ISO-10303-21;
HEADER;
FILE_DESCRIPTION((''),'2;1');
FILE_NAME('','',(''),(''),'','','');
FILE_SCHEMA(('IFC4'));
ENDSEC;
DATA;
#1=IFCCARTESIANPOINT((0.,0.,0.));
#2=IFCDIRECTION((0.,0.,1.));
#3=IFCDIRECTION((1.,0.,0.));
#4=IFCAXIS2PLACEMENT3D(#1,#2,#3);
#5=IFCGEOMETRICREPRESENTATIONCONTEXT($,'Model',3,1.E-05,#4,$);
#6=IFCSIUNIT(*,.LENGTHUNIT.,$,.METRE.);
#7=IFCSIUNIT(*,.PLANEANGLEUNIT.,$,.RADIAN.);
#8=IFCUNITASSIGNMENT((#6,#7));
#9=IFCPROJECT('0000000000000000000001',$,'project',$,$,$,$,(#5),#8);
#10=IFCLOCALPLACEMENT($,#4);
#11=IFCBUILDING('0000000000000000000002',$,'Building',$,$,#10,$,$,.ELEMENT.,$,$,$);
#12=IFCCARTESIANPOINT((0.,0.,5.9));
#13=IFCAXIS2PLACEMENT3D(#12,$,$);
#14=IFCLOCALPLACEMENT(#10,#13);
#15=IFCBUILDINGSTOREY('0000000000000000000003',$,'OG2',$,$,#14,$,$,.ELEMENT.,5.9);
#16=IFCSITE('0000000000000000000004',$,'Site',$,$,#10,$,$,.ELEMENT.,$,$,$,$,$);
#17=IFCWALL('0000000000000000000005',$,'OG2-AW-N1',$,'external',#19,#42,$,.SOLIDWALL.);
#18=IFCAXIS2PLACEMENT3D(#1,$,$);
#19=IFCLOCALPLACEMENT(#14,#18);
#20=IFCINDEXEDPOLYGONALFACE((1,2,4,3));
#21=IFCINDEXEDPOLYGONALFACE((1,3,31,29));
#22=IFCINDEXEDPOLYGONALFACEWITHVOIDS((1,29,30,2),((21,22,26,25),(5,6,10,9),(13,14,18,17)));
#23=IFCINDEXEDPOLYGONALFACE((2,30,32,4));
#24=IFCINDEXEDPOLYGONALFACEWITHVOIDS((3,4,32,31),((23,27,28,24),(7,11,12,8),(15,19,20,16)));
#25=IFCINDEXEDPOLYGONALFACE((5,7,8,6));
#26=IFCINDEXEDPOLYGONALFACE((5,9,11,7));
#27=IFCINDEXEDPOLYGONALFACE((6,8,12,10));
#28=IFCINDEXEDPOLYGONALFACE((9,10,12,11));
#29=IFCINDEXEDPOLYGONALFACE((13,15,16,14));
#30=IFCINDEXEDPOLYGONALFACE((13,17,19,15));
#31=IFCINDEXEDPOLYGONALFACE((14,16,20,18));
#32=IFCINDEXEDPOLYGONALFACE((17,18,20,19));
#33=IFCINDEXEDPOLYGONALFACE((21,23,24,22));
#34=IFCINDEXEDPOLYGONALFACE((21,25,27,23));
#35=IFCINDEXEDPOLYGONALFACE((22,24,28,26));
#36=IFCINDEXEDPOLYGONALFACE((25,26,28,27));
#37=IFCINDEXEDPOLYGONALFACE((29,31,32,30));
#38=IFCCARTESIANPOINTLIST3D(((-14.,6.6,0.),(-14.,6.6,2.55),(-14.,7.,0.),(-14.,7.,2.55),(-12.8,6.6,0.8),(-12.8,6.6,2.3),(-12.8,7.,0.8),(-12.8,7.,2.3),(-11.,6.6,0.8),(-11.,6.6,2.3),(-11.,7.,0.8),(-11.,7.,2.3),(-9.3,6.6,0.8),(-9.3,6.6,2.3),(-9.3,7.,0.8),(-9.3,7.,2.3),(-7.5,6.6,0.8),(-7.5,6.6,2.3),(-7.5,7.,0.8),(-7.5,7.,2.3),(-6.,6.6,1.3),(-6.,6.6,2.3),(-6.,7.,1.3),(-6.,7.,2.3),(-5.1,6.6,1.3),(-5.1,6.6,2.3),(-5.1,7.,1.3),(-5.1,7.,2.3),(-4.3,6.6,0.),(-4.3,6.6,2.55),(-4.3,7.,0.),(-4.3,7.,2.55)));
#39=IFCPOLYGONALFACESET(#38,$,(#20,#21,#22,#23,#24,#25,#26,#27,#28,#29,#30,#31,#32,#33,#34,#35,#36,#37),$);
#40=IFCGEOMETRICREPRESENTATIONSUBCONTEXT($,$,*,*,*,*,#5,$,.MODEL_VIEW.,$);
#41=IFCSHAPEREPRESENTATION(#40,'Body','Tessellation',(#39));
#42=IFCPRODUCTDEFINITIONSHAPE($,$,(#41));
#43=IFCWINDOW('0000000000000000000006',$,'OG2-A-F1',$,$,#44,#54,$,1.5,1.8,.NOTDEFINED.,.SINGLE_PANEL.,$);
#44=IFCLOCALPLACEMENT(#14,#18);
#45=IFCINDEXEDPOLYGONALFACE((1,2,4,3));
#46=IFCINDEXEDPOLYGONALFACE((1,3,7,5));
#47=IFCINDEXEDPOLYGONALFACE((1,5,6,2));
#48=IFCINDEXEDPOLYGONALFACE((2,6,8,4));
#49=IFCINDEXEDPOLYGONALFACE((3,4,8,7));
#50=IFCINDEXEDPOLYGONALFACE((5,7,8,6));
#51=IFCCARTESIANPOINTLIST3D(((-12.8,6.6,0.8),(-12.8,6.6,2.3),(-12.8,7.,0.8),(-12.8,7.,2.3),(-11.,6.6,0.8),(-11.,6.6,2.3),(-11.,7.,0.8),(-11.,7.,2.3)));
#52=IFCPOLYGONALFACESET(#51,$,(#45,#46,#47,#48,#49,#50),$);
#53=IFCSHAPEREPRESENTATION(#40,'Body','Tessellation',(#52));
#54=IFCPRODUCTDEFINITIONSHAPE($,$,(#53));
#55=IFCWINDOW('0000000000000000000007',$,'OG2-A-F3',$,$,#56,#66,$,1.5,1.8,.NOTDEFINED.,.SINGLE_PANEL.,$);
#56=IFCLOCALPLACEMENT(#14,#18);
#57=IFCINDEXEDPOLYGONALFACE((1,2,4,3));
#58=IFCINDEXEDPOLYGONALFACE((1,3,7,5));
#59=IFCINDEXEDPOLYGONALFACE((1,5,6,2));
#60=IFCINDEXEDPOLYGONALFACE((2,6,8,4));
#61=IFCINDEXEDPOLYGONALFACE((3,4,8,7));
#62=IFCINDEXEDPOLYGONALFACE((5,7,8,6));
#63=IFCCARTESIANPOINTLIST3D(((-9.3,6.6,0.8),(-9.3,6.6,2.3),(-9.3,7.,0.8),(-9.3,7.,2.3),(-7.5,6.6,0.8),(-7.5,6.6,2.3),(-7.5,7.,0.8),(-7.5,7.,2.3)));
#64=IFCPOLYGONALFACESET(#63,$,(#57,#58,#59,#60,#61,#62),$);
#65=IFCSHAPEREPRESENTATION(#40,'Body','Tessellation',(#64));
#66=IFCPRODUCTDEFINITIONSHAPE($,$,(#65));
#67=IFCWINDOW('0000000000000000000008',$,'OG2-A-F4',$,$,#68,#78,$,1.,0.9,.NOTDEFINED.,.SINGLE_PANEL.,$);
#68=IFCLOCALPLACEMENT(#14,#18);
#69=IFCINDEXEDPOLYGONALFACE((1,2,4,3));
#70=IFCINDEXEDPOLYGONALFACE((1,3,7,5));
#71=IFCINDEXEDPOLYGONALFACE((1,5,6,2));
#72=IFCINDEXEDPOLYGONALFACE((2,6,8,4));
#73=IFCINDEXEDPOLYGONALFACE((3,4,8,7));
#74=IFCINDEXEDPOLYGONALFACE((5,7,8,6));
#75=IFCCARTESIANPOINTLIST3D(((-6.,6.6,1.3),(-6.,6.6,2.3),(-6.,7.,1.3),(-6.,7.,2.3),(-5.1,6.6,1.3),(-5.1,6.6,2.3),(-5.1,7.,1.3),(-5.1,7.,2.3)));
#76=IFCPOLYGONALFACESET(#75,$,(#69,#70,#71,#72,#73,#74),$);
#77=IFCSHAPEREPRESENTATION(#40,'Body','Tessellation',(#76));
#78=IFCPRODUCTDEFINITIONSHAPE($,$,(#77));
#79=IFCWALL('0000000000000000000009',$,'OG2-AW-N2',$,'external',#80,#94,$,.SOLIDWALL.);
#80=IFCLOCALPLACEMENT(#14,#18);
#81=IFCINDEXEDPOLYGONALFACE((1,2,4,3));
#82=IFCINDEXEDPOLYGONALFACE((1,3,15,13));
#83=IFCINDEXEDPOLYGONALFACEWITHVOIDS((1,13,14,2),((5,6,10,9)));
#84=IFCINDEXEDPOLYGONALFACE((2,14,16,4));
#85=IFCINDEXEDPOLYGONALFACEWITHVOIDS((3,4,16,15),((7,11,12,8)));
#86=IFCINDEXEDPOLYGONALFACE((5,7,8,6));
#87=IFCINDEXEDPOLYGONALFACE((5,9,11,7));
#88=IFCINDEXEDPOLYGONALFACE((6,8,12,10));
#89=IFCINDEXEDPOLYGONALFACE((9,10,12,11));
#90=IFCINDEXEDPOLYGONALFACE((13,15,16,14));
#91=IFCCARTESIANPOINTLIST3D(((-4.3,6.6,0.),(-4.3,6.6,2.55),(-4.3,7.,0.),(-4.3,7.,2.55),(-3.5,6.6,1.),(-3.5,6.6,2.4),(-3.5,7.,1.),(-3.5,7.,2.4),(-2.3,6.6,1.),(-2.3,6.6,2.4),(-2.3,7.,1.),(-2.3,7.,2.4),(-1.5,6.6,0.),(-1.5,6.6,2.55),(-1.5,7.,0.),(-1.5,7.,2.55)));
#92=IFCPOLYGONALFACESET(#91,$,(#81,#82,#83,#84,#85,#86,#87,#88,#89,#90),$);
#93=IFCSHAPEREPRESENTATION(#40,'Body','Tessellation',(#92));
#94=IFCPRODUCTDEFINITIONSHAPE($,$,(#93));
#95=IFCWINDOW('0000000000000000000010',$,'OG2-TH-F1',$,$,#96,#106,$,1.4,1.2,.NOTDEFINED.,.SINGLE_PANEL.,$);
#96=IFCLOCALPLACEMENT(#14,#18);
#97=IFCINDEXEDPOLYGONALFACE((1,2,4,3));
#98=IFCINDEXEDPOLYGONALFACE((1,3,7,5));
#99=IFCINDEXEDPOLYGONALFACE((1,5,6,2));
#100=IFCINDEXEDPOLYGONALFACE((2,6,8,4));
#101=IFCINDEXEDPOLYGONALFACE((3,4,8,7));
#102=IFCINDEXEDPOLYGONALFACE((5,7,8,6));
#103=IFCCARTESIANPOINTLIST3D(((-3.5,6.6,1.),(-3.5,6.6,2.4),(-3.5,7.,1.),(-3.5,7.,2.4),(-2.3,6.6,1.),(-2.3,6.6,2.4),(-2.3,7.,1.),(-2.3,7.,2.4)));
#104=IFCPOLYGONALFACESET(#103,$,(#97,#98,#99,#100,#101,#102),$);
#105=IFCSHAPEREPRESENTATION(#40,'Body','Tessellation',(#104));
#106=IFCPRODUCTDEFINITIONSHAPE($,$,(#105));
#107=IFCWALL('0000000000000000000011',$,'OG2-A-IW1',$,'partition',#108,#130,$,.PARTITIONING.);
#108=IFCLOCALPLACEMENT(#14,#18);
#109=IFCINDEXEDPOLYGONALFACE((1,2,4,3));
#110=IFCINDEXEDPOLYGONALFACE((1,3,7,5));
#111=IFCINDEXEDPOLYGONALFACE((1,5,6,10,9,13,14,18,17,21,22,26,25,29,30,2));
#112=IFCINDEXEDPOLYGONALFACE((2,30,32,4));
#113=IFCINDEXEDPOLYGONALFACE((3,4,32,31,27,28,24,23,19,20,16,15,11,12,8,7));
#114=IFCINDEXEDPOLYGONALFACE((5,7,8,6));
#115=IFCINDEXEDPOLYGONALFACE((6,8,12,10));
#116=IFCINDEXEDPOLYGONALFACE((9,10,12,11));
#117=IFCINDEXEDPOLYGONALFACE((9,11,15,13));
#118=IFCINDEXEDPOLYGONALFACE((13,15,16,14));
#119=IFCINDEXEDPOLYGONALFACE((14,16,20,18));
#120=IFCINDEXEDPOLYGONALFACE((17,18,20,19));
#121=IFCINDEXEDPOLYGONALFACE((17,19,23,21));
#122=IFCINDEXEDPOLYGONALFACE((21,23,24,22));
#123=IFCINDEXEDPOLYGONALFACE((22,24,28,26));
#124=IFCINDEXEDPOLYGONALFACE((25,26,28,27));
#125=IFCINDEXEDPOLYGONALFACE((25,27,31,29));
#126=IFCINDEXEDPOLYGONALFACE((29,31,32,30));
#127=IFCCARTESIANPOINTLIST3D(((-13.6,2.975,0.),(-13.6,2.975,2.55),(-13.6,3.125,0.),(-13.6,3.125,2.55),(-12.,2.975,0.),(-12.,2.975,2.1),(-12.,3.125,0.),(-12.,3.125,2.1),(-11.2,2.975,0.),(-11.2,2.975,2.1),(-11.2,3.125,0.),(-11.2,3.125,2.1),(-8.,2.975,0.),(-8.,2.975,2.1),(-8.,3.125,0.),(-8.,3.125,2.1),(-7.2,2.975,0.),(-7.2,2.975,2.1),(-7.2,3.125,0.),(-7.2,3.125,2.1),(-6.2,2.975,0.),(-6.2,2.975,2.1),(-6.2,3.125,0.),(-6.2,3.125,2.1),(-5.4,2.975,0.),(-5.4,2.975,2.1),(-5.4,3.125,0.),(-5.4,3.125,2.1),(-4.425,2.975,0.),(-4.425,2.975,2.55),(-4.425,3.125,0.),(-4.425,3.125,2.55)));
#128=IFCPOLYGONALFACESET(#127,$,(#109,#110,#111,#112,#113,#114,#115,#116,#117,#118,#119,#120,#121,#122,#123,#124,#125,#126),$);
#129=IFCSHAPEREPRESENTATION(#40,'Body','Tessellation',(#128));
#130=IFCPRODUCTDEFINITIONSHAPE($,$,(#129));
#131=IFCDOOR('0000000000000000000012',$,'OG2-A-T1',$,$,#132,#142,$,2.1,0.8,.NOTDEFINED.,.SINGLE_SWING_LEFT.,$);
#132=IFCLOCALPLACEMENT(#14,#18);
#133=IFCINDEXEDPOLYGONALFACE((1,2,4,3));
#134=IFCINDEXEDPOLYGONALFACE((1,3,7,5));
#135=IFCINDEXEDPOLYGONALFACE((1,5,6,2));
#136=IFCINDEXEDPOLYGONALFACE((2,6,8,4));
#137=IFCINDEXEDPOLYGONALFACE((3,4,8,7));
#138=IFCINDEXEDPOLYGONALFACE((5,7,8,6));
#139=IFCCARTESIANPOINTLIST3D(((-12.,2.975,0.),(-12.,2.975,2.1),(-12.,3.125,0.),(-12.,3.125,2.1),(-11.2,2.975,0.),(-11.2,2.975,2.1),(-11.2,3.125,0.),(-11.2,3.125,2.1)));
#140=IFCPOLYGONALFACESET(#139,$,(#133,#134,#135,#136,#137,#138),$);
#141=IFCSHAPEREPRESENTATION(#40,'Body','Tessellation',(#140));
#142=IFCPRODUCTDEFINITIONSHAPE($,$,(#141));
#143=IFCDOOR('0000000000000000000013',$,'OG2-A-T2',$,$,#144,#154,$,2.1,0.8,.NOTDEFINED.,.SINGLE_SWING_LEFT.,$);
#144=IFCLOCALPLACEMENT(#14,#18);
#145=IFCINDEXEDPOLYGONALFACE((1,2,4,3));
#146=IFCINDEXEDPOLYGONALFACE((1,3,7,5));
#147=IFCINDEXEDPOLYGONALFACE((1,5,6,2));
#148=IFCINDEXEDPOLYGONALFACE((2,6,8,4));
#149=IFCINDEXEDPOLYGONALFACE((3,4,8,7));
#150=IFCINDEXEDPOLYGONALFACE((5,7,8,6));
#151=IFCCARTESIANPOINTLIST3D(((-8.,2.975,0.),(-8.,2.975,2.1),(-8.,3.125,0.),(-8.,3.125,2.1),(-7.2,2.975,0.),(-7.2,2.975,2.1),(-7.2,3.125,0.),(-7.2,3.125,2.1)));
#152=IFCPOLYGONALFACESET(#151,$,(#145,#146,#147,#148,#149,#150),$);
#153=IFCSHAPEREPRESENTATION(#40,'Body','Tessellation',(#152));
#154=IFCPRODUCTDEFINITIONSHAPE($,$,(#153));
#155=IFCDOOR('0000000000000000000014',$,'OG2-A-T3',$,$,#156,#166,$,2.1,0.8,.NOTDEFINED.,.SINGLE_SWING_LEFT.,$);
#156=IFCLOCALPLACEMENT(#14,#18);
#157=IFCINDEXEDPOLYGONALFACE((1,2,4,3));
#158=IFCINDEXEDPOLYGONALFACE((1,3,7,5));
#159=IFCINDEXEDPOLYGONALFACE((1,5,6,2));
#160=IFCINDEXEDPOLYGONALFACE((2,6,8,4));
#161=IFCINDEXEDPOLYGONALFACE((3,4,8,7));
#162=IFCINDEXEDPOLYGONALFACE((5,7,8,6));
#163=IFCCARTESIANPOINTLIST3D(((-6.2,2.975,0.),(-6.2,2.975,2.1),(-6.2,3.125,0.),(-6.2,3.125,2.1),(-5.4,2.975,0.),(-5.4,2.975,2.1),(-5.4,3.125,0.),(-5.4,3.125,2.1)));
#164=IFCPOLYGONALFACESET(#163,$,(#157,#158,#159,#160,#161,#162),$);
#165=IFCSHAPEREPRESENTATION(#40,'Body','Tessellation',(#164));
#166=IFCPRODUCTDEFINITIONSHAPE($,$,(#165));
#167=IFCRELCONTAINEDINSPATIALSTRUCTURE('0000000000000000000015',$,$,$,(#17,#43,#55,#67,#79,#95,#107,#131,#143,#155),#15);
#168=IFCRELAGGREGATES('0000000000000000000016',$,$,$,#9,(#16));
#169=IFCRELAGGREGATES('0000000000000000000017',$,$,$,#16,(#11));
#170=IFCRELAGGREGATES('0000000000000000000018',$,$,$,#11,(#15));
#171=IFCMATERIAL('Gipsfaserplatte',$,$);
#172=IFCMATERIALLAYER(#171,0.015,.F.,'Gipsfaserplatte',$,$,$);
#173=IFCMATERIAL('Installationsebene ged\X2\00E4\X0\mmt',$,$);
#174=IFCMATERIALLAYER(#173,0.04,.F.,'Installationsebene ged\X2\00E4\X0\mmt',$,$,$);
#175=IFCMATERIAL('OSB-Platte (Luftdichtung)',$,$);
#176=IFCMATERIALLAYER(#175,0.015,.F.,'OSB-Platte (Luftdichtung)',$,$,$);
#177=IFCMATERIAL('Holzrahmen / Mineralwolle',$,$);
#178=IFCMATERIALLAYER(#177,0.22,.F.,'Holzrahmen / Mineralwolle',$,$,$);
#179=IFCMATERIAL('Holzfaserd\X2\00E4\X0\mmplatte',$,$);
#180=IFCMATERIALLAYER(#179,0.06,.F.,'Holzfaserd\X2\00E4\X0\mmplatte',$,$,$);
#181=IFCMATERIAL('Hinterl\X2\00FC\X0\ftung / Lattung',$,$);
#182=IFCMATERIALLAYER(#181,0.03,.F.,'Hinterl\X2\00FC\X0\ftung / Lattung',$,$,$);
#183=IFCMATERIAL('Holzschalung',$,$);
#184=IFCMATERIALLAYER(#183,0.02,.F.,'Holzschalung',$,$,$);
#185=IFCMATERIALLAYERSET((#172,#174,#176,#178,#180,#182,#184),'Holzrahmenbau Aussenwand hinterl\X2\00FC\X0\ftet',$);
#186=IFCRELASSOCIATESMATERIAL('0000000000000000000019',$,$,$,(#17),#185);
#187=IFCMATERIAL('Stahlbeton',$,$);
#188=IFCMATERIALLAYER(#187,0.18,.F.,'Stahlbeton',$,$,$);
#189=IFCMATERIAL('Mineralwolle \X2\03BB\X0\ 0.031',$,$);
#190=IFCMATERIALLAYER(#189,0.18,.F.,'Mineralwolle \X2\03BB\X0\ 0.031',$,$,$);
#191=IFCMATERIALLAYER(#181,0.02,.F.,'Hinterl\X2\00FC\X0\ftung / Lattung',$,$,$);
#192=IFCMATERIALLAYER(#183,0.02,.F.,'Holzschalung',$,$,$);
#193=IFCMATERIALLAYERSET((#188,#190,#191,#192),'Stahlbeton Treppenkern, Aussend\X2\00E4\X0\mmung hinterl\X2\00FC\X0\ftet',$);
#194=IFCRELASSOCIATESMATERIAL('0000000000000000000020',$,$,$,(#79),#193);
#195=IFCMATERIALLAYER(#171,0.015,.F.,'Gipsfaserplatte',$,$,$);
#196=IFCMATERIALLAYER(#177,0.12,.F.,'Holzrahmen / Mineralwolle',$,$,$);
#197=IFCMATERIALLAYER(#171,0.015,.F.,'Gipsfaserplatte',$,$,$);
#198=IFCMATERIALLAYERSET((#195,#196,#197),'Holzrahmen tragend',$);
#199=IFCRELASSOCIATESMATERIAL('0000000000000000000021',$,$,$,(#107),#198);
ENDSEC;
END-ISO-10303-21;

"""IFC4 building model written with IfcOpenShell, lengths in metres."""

from ifc_helpers import new_model, si_unit, frame, frame_2d, origin, origin_with_axes, place, context, subcontext, project, spatial, rectangle, extrude, material, layer, layer_set, element, fill, save


model = new_model("IFC4")

# Units and contexts
model_context = context("Model", 3, precision=1e-05, world=origin_with_axes())
sub_context = subcontext(model_context, None, None, "MODEL_VIEW")
ifc_project = project(units=[si_unit("LENGTHUNIT", "METRE"), si_unit("PLANEANGLEUNIT", "RADIAN")], contexts=[model_context])

# Site, building, storey
placement = place(None, origin_with_axes())
site = spatial("IfcSite", under=ifc_project, at=placement, Name="Site", CompositionType="ELEMENT")
building = spatial("IfcBuilding", under=site, at=placement, Name="Building", CompositionType="ELEMENT")
storey_placement = place(placement, frame((0.0, 0.0, 5.9)))
storey = spatial("IfcBuildingStorey", under=building, at=storey_placement, Name="OG2", CompositionType="ELEMENT", Elevation=5.9)

# Wall, openings, windows
ifc_material_1 = material(Name="Gipsfaserplatte")
ifc_layer_1 = layer(ifc_material_1, 0.015, ventilated=False, Name="Gipsfaserplatte")
ifc_material_2 = material(Name="Installationsebene gedämmt")
ifc_layer_2 = layer(ifc_material_2, 0.04, ventilated=False, Name="Installationsebene gedämmt")
ifc_material_3 = material(Name="OSB-Platte (Luftdichtung)")
ifc_layer_3 = layer(ifc_material_3, 0.015, ventilated=False, Name="OSB-Platte (Luftdichtung)")
ifc_material_4 = material(Name="Holzrahmen / Mineralwolle")
ifc_layer_4 = layer(ifc_material_4, 0.22, ventilated=False, Name="Holzrahmen / Mineralwolle")
ifc_material_5 = material(Name="Holzfaserdämmplatte")
ifc_layer_5 = layer(ifc_material_5, 0.06, ventilated=False, Name="Holzfaserdämmplatte")
ifc_material_6 = material(Name="Hinterlüftung / Lattung")
ifc_layer_6 = layer(ifc_material_6, 0.03, ventilated=False, Name="Hinterlüftung / Lattung")
ifc_material_7 = material(Name="Holzschalung")
ifc_layer_7 = layer(ifc_material_7, 0.02, ventilated=False, Name="Holzschalung")
ifc_layer_set_1 = layer_set([ifc_layer_1, ifc_layer_2, ifc_layer_3, ifc_layer_4, ifc_layer_5, ifc_layer_6, ifc_layer_7], Name="Holzrahmenbau Aussenwand hinterlüftet")
wall_1_placement = place(storey_placement, frame((-14.0, 6.8, 0.0), z_axis=(0.0, 0.0, 1.0), x_axis=(1.0, 0.0, 0.0)))
wall_1 = element("IfcWall", 1, at=wall_1_placement, inside=storey, material=ifc_layer_set_1, Name="OG2-AW-N1", ObjectType="external", PredefinedType="SOLIDWALL", context=sub_context, shape_type="SweptSolid", body=[
    extrude(rectangle(XDim=9.7, YDim=0.4, at=frame_2d((4.85, 0.0))), origin(), (0.0, 0.0, 1.0), 2.55),
])
opening_1_placement = place(wall_1_placement, frame((2.1, 0.25, 0.8), z_axis=(0.0, -1.0, 0.0), x_axis=(1.0, 0.0, 0.0)))
opening_1 = element("IfcOpeningElement", 2, at=opening_1_placement, cuts=wall_1, PredefinedType="OPENING", context=sub_context, shape_type="SweptSolid", body=[
    extrude(rectangle(XDim=1.8, YDim=1.5, at=frame_2d((0.0, 0.75))), origin(), (0.0, 0.0, 1.0), 0.5),
])
opening_2_placement = place(wall_1_placement, frame((5.6, 0.25, 0.8), z_axis=(0.0, -1.0, 0.0), x_axis=(1.0, 0.0, 0.0)))
opening_2 = element("IfcOpeningElement", 3, at=opening_2_placement, cuts=wall_1, PredefinedType="OPENING", context=sub_context, shape_type="SweptSolid", body=[
    extrude(rectangle(XDim=1.8, YDim=1.5, at=frame_2d((0.0, 0.75))), origin(), (0.0, 0.0, 1.0), 0.5),
])
opening_3_placement = place(wall_1_placement, frame((8.45, 0.25, 1.3), z_axis=(0.0, -1.0, 0.0), x_axis=(1.0, 0.0, 0.0)))
opening_3 = element("IfcOpeningElement", 4, at=opening_3_placement, cuts=wall_1, PredefinedType="OPENING", context=sub_context, shape_type="SweptSolid", body=[
    extrude(rectangle(XDim=0.9, YDim=1.0, at=frame_2d((0.0, 0.5))), origin(), (0.0, 0.0, 1.0), 0.5),
])
window_1_placement = place(wall_1_placement, frame((2.1, 0.2, 0.8), z_axis=(0.0, -1.0, 0.0), x_axis=(1.0, 0.0, 0.0)))
window_1 = element("IfcWindow", 5, at=window_1_placement, inside=storey, Name="OG2-A-F1", OverallHeight=1.5, OverallWidth=1.8, PartitioningType="SINGLE_PANEL", PredefinedType="NOTDEFINED", context=sub_context, shape_type="SweptSolid", body=[
    extrude(rectangle(XDim=1.8, YDim=1.5, at=frame_2d((0.0, 0.75))), origin(), (0.0, 0.0, 1.0), 0.4),
])
fill(opening_1, window_1)
window_2_placement = place(wall_1_placement, frame((5.6, 0.2, 0.8), z_axis=(0.0, -1.0, 0.0), x_axis=(1.0, 0.0, 0.0)))
window_2 = element("IfcWindow", 6, at=window_2_placement, inside=storey, Name="OG2-A-F3", OverallHeight=1.5, OverallWidth=1.8, PartitioningType="SINGLE_PANEL", PredefinedType="NOTDEFINED", context=sub_context, shape_type="SweptSolid", body=[
    extrude(rectangle(XDim=1.8, YDim=1.5, at=frame_2d((0.0, 0.75))), origin(), (0.0, 0.0, 1.0), 0.4),
])
fill(opening_2, window_2)
window_3_placement = place(wall_1_placement, frame((8.45, 0.2, 1.3), z_axis=(0.0, -1.0, 0.0), x_axis=(1.0, 0.0, 0.0)))
window_3 = element("IfcWindow", 7, at=window_3_placement, inside=storey, Name="OG2-A-F4", OverallHeight=1.0, OverallWidth=0.9, PartitioningType="SINGLE_PANEL", PredefinedType="NOTDEFINED", context=sub_context, shape_type="SweptSolid", body=[
    extrude(rectangle(XDim=0.9, YDim=1.0, at=frame_2d((0.0, 0.5))), origin(), (0.0, 0.0, 1.0), 0.4),
])
fill(opening_3, window_3)

# Wall, opening, window
ifc_material_8 = material(Name="Stahlbeton")
ifc_layer_8 = layer(ifc_material_8, 0.18, ventilated=False, Name="Stahlbeton")
ifc_material_9 = material(Name="Mineralwolle λ 0.031")
ifc_layer_9 = layer(ifc_material_9, 0.18, ventilated=False, Name="Mineralwolle λ 0.031")
ifc_layer_10 = layer(ifc_material_6, 0.02, ventilated=False, Name="Hinterlüftung / Lattung")
ifc_layer_11 = layer(ifc_material_7, 0.02, ventilated=False, Name="Holzschalung")
ifc_layer_set_2 = layer_set([ifc_layer_8, ifc_layer_9, ifc_layer_10, ifc_layer_11], Name="Stahlbeton Treppenkern, Aussendämmung hinterlüftet")
wall_2_placement = place(storey_placement, frame((-4.3, 6.8, 0.0), z_axis=(0.0, 0.0, 1.0), x_axis=(1.0, 0.0, 0.0)))
wall_2 = element("IfcWall", 8, at=wall_2_placement, inside=storey, material=ifc_layer_set_2, Name="OG2-AW-N2", ObjectType="external", PredefinedType="SOLIDWALL", context=sub_context, shape_type="SweptSolid", body=[
    extrude(rectangle(XDim=2.8, YDim=0.4, at=frame_2d((1.4, 0.0))), origin(), (0.0, 0.0, 1.0), 2.55),
])
opening_4_placement = place(wall_2_placement, frame((1.4, 0.25, 1.0), z_axis=(0.0, -1.0, 0.0), x_axis=(1.0, 0.0, 0.0)))
opening_4 = element("IfcOpeningElement", 9, at=opening_4_placement, cuts=wall_2, PredefinedType="OPENING", context=sub_context, shape_type="SweptSolid", body=[
    extrude(rectangle(XDim=1.2, YDim=1.4, at=frame_2d((0.0, 0.7))), origin(), (0.0, 0.0, 1.0), 0.5),
])
window_4_placement = place(wall_2_placement, frame((1.4, 0.2, 1.0), z_axis=(0.0, -1.0, 0.0), x_axis=(1.0, 0.0, 0.0)))
window_4 = element("IfcWindow", 10, at=window_4_placement, inside=storey, Name="OG2-TH-F1", OverallHeight=1.4, OverallWidth=1.2, PartitioningType="SINGLE_PANEL", PredefinedType="NOTDEFINED", context=sub_context, shape_type="SweptSolid", body=[
    extrude(rectangle(XDim=1.2, YDim=1.4, at=frame_2d((0.0, 0.7))), origin(), (0.0, 0.0, 1.0), 0.4),
])
fill(opening_4, window_4)

# Wall, openings, doors
ifc_layer_12 = layer(ifc_material_1, 0.015, ventilated=False, Name="Gipsfaserplatte")
ifc_layer_13 = layer(ifc_material_4, 0.12, ventilated=False, Name="Holzrahmen / Mineralwolle")
ifc_layer_14 = layer(ifc_material_1, 0.015, ventilated=False, Name="Gipsfaserplatte")
ifc_layer_set_3 = layer_set([ifc_layer_12, ifc_layer_13, ifc_layer_14], Name="Holzrahmen tragend")
wall_3_placement = place(storey_placement, frame((-13.6, 3.05, 0.0), z_axis=(0.0, 0.0, 1.0), x_axis=(1.0, 0.0, 0.0)))
wall_3 = element("IfcWall", 11, at=wall_3_placement, inside=storey, material=ifc_layer_set_3, Name="OG2-A-IW1", ObjectType="partition", PredefinedType="PARTITIONING", context=sub_context, shape_type="SweptSolid", body=[
    extrude(rectangle(XDim=9.175, YDim=0.15, at=frame_2d((4.5875, 0.0))), origin(), (0.0, 0.0, 1.0), 2.55),
])
opening_5_placement = place(wall_3_placement, frame((2.0, 0.125, 0.0), z_axis=(0.0, -1.0, 0.0), x_axis=(1.0, 0.0, 0.0)))
opening_5 = element("IfcOpeningElement", 12, at=opening_5_placement, cuts=wall_3, PredefinedType="OPENING", context=sub_context, shape_type="SweptSolid", body=[
    extrude(rectangle(XDim=0.8, YDim=2.1, at=frame_2d((0.0, 1.05))), origin(), (0.0, 0.0, 1.0), 0.25),
])
opening_6_placement = place(wall_3_placement, frame((6.0, 0.125, 0.0), z_axis=(0.0, -1.0, 0.0), x_axis=(1.0, 0.0, 0.0)))
opening_6 = element("IfcOpeningElement", 13, at=opening_6_placement, cuts=wall_3, PredefinedType="OPENING", context=sub_context, shape_type="SweptSolid", body=[
    extrude(rectangle(XDim=0.8, YDim=2.1, at=frame_2d((0.0, 1.05))), origin(), (0.0, 0.0, 1.0), 0.25),
])
opening_7_placement = place(wall_3_placement, frame((7.8, 0.125, 0.0), z_axis=(0.0, -1.0, 0.0), x_axis=(1.0, 0.0, 0.0)))
opening_7 = element("IfcOpeningElement", 14, at=opening_7_placement, cuts=wall_3, PredefinedType="OPENING", context=sub_context, shape_type="SweptSolid", body=[
    extrude(rectangle(XDim=0.8, YDim=2.1, at=frame_2d((0.0, 1.05))), origin(), (0.0, 0.0, 1.0), 0.25),
])
door_1_placement = place(wall_3_placement, frame((2.0, 0.075, 0.0), z_axis=(0.0, -1.0, 0.0), x_axis=(1.0, 0.0, 0.0)))
door_1 = element("IfcDoor", 15, at=door_1_placement, inside=storey, Name="OG2-A-T1", OperationType="SINGLE_SWING_LEFT", OverallHeight=2.1, OverallWidth=0.8, PredefinedType="NOTDEFINED", context=sub_context, shape_type="SweptSolid", body=[
    extrude(rectangle(XDim=0.8, YDim=2.1, at=frame_2d((0.0, 1.05))), origin(), (0.0, 0.0, 1.0), 0.15),
])
fill(opening_5, door_1)
door_2_placement = place(wall_3_placement, frame((6.0, 0.075, 0.0), z_axis=(0.0, -1.0, 0.0), x_axis=(1.0, 0.0, 0.0)))
door_2 = element("IfcDoor", 16, at=door_2_placement, inside=storey, Name="OG2-A-T2", OperationType="SINGLE_SWING_LEFT", OverallHeight=2.1, OverallWidth=0.8, PredefinedType="NOTDEFINED", context=sub_context, shape_type="SweptSolid", body=[
    extrude(rectangle(XDim=0.8, YDim=2.1, at=frame_2d((0.0, 1.05))), origin(), (0.0, 0.0, 1.0), 0.15),
])
fill(opening_6, door_2)
door_3_placement = place(wall_3_placement, frame((7.8, 0.075, 0.0), z_axis=(0.0, -1.0, 0.0), x_axis=(1.0, 0.0, 0.0)))
door_3 = element("IfcDoor", 17, at=door_3_placement, inside=storey, Name="OG2-A-T3", OperationType="SINGLE_SWING_LEFT", OverallHeight=2.1, OverallWidth=0.8, PredefinedType="NOTDEFINED", context=sub_context, shape_type="SweptSolid", body=[
    extrude(rectangle(XDim=0.8, YDim=2.1, at=frame_2d((0.0, 1.05))), origin(), (0.0, 0.0, 1.0), 0.15),
])
fill(opening_7, door_3)

save(model, "model.ifc")
